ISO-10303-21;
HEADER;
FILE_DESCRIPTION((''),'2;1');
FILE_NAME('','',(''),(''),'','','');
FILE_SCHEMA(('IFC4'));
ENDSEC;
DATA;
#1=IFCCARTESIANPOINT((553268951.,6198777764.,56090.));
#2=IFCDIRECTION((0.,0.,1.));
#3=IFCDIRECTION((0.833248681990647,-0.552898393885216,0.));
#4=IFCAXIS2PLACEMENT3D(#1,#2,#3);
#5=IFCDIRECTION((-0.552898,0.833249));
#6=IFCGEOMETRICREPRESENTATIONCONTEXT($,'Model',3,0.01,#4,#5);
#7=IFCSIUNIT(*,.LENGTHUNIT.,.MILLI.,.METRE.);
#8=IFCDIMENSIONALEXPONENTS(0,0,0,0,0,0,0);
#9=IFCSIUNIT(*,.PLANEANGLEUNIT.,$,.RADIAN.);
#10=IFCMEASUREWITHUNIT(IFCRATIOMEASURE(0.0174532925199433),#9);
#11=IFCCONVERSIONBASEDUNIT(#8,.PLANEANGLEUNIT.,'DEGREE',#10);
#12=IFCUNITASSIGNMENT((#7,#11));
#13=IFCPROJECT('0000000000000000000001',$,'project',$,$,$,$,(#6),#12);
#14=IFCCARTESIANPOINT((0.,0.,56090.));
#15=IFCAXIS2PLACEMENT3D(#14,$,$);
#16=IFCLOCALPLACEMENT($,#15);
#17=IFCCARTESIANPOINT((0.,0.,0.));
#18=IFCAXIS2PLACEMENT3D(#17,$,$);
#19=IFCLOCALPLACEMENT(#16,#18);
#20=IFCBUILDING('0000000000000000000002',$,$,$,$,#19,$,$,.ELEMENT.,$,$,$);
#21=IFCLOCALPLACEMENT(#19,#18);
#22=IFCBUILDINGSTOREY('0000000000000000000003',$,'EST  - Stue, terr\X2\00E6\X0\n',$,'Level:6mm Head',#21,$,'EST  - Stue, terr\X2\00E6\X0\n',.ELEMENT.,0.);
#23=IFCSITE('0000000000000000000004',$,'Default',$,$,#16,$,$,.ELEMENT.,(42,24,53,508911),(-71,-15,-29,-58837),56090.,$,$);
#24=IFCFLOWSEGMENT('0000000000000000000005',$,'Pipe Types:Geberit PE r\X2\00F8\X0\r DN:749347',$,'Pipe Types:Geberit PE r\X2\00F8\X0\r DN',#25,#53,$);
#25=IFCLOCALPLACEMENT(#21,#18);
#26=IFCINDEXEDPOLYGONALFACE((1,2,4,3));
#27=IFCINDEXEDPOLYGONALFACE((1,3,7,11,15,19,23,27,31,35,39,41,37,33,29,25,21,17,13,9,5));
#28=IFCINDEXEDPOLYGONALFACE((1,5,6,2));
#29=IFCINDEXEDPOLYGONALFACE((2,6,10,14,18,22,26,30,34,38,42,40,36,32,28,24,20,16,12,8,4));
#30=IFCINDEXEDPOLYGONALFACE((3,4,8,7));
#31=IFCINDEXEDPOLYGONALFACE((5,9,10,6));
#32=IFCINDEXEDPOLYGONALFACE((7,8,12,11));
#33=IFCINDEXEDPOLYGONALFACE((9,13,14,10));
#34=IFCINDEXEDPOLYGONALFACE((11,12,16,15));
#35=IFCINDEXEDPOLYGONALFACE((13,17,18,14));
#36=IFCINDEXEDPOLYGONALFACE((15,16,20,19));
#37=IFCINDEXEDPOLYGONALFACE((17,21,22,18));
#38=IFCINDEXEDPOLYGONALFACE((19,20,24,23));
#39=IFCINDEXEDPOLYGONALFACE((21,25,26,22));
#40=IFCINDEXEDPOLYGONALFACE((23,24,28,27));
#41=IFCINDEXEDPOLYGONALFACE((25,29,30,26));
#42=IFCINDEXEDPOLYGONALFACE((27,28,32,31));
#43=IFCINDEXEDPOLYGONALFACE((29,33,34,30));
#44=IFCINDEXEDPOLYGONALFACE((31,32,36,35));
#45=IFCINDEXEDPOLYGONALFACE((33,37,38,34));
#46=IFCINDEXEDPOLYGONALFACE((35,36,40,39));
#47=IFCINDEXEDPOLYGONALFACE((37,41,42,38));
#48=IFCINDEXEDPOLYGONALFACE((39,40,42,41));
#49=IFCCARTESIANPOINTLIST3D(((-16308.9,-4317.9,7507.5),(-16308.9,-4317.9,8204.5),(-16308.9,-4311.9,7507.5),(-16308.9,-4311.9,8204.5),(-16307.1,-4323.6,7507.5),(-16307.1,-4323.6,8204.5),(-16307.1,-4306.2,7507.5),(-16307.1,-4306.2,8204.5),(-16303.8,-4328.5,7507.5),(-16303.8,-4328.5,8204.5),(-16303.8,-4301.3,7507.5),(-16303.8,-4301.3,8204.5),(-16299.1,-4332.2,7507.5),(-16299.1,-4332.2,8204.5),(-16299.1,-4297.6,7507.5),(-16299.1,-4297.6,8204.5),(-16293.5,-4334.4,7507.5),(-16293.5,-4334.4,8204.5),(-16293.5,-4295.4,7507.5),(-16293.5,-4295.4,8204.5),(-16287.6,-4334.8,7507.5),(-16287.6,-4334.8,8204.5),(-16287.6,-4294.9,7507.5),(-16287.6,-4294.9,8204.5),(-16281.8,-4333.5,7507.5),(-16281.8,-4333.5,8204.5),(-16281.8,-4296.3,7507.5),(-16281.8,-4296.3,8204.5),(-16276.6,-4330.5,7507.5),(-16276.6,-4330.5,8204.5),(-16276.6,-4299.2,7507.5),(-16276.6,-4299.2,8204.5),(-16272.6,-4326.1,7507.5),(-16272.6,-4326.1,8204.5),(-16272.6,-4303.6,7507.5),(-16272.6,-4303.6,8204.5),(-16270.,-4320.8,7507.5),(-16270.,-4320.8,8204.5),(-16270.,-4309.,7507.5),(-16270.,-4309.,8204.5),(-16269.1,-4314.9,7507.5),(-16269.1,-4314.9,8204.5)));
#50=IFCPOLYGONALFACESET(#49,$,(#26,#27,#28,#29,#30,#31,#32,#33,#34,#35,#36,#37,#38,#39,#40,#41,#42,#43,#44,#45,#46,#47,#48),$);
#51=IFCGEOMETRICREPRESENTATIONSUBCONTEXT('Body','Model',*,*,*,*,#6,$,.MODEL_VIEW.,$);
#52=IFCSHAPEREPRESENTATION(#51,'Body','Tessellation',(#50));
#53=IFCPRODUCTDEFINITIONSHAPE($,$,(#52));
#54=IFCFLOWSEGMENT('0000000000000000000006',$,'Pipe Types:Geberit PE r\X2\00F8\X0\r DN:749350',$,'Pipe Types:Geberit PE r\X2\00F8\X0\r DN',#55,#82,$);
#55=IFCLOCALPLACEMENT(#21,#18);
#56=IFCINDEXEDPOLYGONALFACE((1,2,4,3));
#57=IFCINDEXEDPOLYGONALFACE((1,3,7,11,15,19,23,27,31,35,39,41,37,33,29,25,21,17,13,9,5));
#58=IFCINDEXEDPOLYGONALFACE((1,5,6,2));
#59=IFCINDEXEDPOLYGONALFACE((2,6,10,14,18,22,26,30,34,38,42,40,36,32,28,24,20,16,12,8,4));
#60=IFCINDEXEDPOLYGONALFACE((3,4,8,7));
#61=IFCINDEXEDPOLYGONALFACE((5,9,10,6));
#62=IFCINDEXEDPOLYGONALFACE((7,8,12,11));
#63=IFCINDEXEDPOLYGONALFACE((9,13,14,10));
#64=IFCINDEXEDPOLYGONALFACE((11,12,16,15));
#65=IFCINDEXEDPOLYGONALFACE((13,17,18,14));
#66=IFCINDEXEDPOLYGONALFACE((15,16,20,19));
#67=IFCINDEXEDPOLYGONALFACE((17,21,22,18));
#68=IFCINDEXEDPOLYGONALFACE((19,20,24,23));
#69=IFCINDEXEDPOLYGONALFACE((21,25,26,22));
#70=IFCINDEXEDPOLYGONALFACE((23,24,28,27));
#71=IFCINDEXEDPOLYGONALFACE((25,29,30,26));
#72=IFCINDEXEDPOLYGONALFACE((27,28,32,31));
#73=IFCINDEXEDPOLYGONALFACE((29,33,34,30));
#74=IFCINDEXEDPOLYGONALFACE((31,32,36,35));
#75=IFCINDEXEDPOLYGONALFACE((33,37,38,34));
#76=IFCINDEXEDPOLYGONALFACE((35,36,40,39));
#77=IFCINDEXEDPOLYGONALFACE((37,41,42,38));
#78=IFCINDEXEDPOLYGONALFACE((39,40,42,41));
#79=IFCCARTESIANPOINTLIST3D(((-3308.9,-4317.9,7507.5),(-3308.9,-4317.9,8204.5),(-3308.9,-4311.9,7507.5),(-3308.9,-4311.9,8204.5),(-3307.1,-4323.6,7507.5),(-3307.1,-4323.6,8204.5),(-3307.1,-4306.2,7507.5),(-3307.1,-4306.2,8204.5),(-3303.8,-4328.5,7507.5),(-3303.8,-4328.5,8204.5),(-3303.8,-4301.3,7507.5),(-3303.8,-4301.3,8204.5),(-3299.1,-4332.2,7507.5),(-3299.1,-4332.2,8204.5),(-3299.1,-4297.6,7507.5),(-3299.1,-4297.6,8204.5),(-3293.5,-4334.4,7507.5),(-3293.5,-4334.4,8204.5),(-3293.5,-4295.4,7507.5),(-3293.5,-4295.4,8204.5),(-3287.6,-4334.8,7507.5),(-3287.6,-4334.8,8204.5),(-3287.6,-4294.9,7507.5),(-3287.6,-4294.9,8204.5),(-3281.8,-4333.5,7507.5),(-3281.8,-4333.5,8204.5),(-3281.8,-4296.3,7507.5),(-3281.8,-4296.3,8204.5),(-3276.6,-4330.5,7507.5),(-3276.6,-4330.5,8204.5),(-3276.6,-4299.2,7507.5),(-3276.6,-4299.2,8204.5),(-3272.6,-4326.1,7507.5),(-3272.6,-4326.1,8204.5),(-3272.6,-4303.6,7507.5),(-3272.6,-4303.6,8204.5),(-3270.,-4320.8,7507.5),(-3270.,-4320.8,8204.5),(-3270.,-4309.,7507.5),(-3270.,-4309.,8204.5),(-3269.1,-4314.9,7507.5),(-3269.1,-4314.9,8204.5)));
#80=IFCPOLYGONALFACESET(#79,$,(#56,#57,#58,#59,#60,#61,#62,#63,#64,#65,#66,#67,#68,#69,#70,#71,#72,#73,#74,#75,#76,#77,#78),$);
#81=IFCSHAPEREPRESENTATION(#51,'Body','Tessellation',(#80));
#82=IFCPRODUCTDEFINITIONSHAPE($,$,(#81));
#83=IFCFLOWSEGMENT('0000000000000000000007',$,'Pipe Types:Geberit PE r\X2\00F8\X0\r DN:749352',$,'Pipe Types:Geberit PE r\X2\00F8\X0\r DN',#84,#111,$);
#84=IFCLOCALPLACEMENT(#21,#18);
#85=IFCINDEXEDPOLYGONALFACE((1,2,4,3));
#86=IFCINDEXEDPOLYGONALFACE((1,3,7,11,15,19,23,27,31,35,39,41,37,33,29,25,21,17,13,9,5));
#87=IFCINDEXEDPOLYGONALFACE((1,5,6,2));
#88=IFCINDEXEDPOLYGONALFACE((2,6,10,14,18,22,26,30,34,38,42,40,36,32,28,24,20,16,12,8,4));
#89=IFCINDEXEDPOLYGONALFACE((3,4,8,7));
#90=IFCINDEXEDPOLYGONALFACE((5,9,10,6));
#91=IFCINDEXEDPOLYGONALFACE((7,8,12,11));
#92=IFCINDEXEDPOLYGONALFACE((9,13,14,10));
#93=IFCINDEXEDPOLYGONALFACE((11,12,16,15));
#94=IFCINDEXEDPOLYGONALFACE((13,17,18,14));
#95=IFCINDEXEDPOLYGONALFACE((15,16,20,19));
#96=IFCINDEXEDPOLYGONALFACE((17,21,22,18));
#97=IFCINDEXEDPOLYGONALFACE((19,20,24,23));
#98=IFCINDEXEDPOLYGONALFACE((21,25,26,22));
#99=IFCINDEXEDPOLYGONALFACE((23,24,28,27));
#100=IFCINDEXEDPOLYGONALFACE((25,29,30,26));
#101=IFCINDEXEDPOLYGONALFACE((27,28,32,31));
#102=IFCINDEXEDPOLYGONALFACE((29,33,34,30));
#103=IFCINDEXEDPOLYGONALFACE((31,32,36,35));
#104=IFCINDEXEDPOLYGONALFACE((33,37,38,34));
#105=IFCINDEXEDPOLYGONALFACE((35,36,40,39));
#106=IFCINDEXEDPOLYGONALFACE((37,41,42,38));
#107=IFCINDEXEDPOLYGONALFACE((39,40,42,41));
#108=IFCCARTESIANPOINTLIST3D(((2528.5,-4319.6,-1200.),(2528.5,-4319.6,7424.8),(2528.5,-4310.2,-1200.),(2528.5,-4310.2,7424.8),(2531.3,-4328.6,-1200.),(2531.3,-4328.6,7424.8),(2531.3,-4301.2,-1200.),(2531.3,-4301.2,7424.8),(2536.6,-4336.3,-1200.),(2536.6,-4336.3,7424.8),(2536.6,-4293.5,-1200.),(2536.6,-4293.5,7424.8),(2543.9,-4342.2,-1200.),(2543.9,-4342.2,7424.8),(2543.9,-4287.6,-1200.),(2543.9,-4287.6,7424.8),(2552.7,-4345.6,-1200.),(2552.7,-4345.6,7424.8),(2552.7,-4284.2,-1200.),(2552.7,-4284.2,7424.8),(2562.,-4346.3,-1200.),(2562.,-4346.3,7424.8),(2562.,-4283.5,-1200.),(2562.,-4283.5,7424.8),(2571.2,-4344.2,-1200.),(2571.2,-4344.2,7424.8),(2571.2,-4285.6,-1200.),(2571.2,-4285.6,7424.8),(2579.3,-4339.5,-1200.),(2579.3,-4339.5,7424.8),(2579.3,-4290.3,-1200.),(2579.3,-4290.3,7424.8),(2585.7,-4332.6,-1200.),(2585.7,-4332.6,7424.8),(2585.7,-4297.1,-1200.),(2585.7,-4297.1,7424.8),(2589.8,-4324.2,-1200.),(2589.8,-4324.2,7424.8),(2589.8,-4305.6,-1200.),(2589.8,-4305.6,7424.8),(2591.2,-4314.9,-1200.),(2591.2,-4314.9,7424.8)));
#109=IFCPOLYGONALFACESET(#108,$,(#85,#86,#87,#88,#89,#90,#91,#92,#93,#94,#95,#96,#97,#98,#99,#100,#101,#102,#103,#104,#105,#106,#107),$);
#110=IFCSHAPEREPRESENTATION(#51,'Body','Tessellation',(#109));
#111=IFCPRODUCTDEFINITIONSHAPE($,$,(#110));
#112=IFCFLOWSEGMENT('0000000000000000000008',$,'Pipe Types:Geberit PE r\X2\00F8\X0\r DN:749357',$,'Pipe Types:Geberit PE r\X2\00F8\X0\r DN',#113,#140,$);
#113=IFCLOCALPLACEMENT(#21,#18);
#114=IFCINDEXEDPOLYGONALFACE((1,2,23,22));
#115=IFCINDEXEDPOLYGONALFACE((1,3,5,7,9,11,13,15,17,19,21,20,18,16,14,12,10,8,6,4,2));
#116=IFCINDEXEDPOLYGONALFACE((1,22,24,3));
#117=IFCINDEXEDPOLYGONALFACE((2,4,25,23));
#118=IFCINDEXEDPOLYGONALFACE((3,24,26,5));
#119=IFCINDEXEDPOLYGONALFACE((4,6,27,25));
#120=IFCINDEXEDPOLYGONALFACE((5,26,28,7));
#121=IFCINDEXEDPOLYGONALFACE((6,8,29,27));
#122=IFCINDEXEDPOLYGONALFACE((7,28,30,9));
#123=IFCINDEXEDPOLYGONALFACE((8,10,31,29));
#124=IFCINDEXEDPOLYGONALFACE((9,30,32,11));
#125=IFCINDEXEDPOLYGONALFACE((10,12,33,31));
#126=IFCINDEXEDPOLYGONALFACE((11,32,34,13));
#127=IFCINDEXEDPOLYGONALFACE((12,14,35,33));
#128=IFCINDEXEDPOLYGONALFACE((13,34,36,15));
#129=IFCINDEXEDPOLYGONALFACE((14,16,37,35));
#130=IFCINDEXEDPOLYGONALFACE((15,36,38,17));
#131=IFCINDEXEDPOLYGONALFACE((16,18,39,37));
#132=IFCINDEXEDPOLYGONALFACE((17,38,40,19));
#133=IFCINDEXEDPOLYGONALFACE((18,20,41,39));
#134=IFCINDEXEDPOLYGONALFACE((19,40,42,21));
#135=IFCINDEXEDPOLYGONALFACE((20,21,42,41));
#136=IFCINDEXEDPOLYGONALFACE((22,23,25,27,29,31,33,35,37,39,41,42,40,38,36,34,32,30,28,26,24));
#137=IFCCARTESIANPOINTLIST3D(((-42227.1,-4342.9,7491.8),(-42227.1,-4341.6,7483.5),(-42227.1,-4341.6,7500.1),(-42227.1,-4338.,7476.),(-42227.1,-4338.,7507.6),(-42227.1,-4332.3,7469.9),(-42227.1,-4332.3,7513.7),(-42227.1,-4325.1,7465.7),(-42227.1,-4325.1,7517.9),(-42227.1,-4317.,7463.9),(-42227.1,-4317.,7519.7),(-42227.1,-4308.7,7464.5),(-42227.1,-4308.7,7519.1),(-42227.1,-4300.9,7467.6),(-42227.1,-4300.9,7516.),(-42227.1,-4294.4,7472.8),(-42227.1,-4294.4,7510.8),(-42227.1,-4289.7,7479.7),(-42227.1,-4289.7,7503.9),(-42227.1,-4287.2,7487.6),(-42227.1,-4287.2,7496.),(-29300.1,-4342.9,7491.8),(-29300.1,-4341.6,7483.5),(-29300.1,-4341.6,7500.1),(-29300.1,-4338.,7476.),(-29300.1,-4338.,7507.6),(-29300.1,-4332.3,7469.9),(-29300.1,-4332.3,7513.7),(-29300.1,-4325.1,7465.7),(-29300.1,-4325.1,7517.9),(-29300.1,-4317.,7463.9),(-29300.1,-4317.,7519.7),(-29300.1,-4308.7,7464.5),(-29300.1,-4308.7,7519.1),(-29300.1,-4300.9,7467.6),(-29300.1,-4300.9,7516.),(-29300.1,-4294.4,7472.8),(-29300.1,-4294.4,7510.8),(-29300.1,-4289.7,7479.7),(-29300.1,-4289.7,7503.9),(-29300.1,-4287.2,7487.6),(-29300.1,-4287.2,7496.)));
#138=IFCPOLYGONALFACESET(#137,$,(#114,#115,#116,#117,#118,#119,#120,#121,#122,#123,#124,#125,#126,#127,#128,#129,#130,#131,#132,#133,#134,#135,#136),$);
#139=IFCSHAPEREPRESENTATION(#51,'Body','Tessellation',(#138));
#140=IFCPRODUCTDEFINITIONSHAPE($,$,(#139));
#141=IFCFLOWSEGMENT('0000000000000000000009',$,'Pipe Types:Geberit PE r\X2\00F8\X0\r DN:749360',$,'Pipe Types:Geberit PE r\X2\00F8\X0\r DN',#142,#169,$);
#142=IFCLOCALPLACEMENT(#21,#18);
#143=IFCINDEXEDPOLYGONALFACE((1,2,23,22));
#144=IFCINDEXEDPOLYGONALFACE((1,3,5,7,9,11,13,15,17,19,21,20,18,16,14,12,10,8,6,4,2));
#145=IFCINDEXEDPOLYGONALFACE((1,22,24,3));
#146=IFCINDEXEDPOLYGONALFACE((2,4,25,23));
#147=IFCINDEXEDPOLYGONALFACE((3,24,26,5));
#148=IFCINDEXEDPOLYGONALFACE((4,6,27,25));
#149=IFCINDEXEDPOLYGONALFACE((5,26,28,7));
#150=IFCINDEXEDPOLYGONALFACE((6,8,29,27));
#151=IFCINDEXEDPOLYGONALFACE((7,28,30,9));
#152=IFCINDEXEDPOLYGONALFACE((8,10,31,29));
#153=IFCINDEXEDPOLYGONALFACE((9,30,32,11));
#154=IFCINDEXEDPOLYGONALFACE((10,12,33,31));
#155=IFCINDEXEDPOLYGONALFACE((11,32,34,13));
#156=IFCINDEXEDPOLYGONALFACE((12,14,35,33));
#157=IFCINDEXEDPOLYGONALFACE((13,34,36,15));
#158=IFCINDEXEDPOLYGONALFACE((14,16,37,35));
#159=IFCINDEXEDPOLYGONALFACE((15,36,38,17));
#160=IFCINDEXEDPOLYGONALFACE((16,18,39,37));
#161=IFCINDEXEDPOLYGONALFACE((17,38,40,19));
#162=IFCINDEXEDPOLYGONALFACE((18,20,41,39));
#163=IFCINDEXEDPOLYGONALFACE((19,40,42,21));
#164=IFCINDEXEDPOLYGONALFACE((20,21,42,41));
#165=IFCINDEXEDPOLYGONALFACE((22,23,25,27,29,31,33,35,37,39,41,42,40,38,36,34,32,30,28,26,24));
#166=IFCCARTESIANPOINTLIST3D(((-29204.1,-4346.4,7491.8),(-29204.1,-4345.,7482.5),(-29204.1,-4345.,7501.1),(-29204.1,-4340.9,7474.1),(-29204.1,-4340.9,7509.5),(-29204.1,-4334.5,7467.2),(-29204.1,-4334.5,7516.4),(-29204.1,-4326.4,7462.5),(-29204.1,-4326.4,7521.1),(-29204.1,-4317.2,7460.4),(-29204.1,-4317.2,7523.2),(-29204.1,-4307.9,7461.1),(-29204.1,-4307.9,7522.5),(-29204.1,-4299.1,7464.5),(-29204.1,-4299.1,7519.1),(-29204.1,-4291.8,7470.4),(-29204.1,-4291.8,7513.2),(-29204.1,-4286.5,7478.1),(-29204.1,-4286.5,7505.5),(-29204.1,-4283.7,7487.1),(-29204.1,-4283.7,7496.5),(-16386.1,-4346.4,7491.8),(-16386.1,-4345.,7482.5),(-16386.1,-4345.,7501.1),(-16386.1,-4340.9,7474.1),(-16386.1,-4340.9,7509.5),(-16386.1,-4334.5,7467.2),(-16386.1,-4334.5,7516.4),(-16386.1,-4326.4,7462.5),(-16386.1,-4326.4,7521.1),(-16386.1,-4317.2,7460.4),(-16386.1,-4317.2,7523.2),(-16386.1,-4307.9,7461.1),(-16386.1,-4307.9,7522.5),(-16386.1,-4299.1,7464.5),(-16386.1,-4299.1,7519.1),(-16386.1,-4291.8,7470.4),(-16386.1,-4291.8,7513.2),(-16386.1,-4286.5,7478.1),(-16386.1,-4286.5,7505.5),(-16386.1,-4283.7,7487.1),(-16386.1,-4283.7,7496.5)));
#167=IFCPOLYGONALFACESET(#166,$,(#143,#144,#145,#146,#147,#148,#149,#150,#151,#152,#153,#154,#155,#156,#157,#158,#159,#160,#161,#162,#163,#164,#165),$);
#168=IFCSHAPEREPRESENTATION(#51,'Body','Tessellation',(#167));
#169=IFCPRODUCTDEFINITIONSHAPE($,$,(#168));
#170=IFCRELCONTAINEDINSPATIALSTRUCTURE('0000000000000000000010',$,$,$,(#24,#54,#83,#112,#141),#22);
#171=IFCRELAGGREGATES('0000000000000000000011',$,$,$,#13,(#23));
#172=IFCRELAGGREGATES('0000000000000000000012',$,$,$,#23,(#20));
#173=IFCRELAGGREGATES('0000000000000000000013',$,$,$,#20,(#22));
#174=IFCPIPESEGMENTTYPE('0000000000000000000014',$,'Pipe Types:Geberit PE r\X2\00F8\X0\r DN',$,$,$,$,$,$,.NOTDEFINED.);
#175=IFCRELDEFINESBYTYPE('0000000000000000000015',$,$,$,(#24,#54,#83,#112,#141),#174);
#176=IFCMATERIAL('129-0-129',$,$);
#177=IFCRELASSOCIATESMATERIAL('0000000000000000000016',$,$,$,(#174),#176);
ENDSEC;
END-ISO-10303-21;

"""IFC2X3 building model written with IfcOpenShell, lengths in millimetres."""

from ifc_helpers import new_model, entity, si_unit, converted_unit, direction, frame, frame_2d, origin, origin_2d_with_axis, place, context, subcontext, project, spatial, circle, extrude, material, type_object, element, save


model = new_model("IFC2X3")

# Units and contexts
model_context = context("Model", 3, precision=0.01, world=frame((553268951.0, 6198777764.0, 56090.0), z_axis=(0.0, 0.0, 1.0), x_axis=(0.833248681990647, -0.552898393885216, 0.0)), true_north=direction((-0.552898, 0.833249)))
body_context = subcontext(model_context, "Body", "Model", "MODEL_VIEW")
ifc_project = project(units=[si_unit("LENGTHUNIT", "METRE", prefix="MILLI"), converted_unit("PLANEANGLEUNIT", "DEGREE", entity("IfcRatioMeasure", 0.0174532925199433), si_unit("PLANEANGLEUNIT", "RADIAN"), dimensions=[0, 0, 0, 0, 0, 0, 0])], contexts=[model_context])

# Site, building, storey
site_placement = place(None, frame((0.0, 0.0, 56090.0)))
site = spatial("IfcSite", under=ifc_project, at=site_placement, Name="Default", CompositionType="ELEMENT", RefLatitude=(42, 24, 53, 508911), RefLongitude=(-71, -15, -29, -58837), RefElevation=56090.0)
building_placement = place(site_placement, origin())
building = spatial("IfcBuilding", under=site, at=building_placement, CompositionType="ELEMENT")
storey_placement = place(building_placement, frame((0.0, 0.0, 0.0)))
storey = spatial("IfcBuildingStorey", under=building, at=storey_placement, Name="EST  - Stue, terræn", ObjectType="Level:6mm Head", LongName="EST  - Stue, terræn", CompositionType="ELEMENT", Elevation=0.0)

# Flow segments
ifc_material_1 = material(Name="129-0-129")
pipe_segment_type_1 = type_object("IfcPipeSegmentType", Name="Pipe Types:Geberit PE rør DN", PredefinedType="NOTDEFINED", material=ifc_material_1)
flow_segment_1_placement = place(storey_placement, origin())
element("IfcFlowSegment", 1, at=flow_segment_1_placement, inside=storey, type_object=pipe_segment_type_1, Name="Pipe Types:Geberit PE rør DN:749347", ObjectType="Pipe Types:Geberit PE rør DN", context=body_context, shape_type="SweptSolid", body=[
    extrude(circle(Radius=20.0, at=origin_2d_with_axis()), frame((-16289.1, -4314.9, 7507.5)), (0.0, 0.0, 1.0), 696.9),
])
flow_segment_2_placement = place(storey_placement, origin())
element("IfcFlowSegment", 2, at=flow_segment_2_placement, inside=storey, type_object=pipe_segment_type_1, Name="Pipe Types:Geberit PE rør DN:749350", ObjectType="Pipe Types:Geberit PE rør DN", context=body_context, shape_type="SweptSolid", body=[
    extrude(circle(Radius=20.0, at=origin_2d_with_axis()), frame((-3289.1, -4314.9, 7507.5)), (0.0, 0.0, 1.0), 696.9),
])
flow_segment_3_placement = place(storey_placement, origin())
element("IfcFlowSegment", 3, at=flow_segment_3_placement, inside=storey, type_object=pipe_segment_type_1, Name="Pipe Types:Geberit PE rør DN:749352", ObjectType="Pipe Types:Geberit PE rør DN", context=body_context, shape_type="SweptSolid", body=[
    extrude(circle(Radius=31.5, at=origin_2d_with_axis()), frame((2559.7, -4314.9, -1200.0)), (0.0, 0.0, 1.0), 8624.8),
])
flow_segment_4_placement = place(storey_placement, origin())
element("IfcFlowSegment", 4, at=flow_segment_4_placement, inside=storey, type_object=pipe_segment_type_1, Name="Pipe Types:Geberit PE rør DN:749357", ObjectType="Pipe Types:Geberit PE rør DN", context=body_context, shape_type="SweptSolid", body=[
    extrude(circle(Radius=28.0, at=origin_2d_with_axis()), frame((-42227.1, -4314.9, 7491.8), z_axis=(1.0, 0.0, 0.0), x_axis=(0.0, -1.0, 0.0)), (0.0, 0.0, 1.0), 12927.0),
])
flow_segment_5_placement = place(storey_placement, origin())
element("IfcFlowSegment", 5, at=flow_segment_5_placement, inside=storey, type_object=pipe_segment_type_1, Name="Pipe Types:Geberit PE rør DN:749360", ObjectType="Pipe Types:Geberit PE rør DN", context=body_context, shape_type="SweptSolid", body=[
    extrude(circle(Radius=31.5, at=frame_2d((0.0, 0.0), x_axis=(1.0, 0.0))), frame((-29204.1, -4314.9, 7491.8), z_axis=(1.0, 0.0, 0.0), x_axis=(0.0, -1.0, 0.0)), (0.0, 0.0, 1.0), 12818.0),
])

save(model, "model.ifc")
